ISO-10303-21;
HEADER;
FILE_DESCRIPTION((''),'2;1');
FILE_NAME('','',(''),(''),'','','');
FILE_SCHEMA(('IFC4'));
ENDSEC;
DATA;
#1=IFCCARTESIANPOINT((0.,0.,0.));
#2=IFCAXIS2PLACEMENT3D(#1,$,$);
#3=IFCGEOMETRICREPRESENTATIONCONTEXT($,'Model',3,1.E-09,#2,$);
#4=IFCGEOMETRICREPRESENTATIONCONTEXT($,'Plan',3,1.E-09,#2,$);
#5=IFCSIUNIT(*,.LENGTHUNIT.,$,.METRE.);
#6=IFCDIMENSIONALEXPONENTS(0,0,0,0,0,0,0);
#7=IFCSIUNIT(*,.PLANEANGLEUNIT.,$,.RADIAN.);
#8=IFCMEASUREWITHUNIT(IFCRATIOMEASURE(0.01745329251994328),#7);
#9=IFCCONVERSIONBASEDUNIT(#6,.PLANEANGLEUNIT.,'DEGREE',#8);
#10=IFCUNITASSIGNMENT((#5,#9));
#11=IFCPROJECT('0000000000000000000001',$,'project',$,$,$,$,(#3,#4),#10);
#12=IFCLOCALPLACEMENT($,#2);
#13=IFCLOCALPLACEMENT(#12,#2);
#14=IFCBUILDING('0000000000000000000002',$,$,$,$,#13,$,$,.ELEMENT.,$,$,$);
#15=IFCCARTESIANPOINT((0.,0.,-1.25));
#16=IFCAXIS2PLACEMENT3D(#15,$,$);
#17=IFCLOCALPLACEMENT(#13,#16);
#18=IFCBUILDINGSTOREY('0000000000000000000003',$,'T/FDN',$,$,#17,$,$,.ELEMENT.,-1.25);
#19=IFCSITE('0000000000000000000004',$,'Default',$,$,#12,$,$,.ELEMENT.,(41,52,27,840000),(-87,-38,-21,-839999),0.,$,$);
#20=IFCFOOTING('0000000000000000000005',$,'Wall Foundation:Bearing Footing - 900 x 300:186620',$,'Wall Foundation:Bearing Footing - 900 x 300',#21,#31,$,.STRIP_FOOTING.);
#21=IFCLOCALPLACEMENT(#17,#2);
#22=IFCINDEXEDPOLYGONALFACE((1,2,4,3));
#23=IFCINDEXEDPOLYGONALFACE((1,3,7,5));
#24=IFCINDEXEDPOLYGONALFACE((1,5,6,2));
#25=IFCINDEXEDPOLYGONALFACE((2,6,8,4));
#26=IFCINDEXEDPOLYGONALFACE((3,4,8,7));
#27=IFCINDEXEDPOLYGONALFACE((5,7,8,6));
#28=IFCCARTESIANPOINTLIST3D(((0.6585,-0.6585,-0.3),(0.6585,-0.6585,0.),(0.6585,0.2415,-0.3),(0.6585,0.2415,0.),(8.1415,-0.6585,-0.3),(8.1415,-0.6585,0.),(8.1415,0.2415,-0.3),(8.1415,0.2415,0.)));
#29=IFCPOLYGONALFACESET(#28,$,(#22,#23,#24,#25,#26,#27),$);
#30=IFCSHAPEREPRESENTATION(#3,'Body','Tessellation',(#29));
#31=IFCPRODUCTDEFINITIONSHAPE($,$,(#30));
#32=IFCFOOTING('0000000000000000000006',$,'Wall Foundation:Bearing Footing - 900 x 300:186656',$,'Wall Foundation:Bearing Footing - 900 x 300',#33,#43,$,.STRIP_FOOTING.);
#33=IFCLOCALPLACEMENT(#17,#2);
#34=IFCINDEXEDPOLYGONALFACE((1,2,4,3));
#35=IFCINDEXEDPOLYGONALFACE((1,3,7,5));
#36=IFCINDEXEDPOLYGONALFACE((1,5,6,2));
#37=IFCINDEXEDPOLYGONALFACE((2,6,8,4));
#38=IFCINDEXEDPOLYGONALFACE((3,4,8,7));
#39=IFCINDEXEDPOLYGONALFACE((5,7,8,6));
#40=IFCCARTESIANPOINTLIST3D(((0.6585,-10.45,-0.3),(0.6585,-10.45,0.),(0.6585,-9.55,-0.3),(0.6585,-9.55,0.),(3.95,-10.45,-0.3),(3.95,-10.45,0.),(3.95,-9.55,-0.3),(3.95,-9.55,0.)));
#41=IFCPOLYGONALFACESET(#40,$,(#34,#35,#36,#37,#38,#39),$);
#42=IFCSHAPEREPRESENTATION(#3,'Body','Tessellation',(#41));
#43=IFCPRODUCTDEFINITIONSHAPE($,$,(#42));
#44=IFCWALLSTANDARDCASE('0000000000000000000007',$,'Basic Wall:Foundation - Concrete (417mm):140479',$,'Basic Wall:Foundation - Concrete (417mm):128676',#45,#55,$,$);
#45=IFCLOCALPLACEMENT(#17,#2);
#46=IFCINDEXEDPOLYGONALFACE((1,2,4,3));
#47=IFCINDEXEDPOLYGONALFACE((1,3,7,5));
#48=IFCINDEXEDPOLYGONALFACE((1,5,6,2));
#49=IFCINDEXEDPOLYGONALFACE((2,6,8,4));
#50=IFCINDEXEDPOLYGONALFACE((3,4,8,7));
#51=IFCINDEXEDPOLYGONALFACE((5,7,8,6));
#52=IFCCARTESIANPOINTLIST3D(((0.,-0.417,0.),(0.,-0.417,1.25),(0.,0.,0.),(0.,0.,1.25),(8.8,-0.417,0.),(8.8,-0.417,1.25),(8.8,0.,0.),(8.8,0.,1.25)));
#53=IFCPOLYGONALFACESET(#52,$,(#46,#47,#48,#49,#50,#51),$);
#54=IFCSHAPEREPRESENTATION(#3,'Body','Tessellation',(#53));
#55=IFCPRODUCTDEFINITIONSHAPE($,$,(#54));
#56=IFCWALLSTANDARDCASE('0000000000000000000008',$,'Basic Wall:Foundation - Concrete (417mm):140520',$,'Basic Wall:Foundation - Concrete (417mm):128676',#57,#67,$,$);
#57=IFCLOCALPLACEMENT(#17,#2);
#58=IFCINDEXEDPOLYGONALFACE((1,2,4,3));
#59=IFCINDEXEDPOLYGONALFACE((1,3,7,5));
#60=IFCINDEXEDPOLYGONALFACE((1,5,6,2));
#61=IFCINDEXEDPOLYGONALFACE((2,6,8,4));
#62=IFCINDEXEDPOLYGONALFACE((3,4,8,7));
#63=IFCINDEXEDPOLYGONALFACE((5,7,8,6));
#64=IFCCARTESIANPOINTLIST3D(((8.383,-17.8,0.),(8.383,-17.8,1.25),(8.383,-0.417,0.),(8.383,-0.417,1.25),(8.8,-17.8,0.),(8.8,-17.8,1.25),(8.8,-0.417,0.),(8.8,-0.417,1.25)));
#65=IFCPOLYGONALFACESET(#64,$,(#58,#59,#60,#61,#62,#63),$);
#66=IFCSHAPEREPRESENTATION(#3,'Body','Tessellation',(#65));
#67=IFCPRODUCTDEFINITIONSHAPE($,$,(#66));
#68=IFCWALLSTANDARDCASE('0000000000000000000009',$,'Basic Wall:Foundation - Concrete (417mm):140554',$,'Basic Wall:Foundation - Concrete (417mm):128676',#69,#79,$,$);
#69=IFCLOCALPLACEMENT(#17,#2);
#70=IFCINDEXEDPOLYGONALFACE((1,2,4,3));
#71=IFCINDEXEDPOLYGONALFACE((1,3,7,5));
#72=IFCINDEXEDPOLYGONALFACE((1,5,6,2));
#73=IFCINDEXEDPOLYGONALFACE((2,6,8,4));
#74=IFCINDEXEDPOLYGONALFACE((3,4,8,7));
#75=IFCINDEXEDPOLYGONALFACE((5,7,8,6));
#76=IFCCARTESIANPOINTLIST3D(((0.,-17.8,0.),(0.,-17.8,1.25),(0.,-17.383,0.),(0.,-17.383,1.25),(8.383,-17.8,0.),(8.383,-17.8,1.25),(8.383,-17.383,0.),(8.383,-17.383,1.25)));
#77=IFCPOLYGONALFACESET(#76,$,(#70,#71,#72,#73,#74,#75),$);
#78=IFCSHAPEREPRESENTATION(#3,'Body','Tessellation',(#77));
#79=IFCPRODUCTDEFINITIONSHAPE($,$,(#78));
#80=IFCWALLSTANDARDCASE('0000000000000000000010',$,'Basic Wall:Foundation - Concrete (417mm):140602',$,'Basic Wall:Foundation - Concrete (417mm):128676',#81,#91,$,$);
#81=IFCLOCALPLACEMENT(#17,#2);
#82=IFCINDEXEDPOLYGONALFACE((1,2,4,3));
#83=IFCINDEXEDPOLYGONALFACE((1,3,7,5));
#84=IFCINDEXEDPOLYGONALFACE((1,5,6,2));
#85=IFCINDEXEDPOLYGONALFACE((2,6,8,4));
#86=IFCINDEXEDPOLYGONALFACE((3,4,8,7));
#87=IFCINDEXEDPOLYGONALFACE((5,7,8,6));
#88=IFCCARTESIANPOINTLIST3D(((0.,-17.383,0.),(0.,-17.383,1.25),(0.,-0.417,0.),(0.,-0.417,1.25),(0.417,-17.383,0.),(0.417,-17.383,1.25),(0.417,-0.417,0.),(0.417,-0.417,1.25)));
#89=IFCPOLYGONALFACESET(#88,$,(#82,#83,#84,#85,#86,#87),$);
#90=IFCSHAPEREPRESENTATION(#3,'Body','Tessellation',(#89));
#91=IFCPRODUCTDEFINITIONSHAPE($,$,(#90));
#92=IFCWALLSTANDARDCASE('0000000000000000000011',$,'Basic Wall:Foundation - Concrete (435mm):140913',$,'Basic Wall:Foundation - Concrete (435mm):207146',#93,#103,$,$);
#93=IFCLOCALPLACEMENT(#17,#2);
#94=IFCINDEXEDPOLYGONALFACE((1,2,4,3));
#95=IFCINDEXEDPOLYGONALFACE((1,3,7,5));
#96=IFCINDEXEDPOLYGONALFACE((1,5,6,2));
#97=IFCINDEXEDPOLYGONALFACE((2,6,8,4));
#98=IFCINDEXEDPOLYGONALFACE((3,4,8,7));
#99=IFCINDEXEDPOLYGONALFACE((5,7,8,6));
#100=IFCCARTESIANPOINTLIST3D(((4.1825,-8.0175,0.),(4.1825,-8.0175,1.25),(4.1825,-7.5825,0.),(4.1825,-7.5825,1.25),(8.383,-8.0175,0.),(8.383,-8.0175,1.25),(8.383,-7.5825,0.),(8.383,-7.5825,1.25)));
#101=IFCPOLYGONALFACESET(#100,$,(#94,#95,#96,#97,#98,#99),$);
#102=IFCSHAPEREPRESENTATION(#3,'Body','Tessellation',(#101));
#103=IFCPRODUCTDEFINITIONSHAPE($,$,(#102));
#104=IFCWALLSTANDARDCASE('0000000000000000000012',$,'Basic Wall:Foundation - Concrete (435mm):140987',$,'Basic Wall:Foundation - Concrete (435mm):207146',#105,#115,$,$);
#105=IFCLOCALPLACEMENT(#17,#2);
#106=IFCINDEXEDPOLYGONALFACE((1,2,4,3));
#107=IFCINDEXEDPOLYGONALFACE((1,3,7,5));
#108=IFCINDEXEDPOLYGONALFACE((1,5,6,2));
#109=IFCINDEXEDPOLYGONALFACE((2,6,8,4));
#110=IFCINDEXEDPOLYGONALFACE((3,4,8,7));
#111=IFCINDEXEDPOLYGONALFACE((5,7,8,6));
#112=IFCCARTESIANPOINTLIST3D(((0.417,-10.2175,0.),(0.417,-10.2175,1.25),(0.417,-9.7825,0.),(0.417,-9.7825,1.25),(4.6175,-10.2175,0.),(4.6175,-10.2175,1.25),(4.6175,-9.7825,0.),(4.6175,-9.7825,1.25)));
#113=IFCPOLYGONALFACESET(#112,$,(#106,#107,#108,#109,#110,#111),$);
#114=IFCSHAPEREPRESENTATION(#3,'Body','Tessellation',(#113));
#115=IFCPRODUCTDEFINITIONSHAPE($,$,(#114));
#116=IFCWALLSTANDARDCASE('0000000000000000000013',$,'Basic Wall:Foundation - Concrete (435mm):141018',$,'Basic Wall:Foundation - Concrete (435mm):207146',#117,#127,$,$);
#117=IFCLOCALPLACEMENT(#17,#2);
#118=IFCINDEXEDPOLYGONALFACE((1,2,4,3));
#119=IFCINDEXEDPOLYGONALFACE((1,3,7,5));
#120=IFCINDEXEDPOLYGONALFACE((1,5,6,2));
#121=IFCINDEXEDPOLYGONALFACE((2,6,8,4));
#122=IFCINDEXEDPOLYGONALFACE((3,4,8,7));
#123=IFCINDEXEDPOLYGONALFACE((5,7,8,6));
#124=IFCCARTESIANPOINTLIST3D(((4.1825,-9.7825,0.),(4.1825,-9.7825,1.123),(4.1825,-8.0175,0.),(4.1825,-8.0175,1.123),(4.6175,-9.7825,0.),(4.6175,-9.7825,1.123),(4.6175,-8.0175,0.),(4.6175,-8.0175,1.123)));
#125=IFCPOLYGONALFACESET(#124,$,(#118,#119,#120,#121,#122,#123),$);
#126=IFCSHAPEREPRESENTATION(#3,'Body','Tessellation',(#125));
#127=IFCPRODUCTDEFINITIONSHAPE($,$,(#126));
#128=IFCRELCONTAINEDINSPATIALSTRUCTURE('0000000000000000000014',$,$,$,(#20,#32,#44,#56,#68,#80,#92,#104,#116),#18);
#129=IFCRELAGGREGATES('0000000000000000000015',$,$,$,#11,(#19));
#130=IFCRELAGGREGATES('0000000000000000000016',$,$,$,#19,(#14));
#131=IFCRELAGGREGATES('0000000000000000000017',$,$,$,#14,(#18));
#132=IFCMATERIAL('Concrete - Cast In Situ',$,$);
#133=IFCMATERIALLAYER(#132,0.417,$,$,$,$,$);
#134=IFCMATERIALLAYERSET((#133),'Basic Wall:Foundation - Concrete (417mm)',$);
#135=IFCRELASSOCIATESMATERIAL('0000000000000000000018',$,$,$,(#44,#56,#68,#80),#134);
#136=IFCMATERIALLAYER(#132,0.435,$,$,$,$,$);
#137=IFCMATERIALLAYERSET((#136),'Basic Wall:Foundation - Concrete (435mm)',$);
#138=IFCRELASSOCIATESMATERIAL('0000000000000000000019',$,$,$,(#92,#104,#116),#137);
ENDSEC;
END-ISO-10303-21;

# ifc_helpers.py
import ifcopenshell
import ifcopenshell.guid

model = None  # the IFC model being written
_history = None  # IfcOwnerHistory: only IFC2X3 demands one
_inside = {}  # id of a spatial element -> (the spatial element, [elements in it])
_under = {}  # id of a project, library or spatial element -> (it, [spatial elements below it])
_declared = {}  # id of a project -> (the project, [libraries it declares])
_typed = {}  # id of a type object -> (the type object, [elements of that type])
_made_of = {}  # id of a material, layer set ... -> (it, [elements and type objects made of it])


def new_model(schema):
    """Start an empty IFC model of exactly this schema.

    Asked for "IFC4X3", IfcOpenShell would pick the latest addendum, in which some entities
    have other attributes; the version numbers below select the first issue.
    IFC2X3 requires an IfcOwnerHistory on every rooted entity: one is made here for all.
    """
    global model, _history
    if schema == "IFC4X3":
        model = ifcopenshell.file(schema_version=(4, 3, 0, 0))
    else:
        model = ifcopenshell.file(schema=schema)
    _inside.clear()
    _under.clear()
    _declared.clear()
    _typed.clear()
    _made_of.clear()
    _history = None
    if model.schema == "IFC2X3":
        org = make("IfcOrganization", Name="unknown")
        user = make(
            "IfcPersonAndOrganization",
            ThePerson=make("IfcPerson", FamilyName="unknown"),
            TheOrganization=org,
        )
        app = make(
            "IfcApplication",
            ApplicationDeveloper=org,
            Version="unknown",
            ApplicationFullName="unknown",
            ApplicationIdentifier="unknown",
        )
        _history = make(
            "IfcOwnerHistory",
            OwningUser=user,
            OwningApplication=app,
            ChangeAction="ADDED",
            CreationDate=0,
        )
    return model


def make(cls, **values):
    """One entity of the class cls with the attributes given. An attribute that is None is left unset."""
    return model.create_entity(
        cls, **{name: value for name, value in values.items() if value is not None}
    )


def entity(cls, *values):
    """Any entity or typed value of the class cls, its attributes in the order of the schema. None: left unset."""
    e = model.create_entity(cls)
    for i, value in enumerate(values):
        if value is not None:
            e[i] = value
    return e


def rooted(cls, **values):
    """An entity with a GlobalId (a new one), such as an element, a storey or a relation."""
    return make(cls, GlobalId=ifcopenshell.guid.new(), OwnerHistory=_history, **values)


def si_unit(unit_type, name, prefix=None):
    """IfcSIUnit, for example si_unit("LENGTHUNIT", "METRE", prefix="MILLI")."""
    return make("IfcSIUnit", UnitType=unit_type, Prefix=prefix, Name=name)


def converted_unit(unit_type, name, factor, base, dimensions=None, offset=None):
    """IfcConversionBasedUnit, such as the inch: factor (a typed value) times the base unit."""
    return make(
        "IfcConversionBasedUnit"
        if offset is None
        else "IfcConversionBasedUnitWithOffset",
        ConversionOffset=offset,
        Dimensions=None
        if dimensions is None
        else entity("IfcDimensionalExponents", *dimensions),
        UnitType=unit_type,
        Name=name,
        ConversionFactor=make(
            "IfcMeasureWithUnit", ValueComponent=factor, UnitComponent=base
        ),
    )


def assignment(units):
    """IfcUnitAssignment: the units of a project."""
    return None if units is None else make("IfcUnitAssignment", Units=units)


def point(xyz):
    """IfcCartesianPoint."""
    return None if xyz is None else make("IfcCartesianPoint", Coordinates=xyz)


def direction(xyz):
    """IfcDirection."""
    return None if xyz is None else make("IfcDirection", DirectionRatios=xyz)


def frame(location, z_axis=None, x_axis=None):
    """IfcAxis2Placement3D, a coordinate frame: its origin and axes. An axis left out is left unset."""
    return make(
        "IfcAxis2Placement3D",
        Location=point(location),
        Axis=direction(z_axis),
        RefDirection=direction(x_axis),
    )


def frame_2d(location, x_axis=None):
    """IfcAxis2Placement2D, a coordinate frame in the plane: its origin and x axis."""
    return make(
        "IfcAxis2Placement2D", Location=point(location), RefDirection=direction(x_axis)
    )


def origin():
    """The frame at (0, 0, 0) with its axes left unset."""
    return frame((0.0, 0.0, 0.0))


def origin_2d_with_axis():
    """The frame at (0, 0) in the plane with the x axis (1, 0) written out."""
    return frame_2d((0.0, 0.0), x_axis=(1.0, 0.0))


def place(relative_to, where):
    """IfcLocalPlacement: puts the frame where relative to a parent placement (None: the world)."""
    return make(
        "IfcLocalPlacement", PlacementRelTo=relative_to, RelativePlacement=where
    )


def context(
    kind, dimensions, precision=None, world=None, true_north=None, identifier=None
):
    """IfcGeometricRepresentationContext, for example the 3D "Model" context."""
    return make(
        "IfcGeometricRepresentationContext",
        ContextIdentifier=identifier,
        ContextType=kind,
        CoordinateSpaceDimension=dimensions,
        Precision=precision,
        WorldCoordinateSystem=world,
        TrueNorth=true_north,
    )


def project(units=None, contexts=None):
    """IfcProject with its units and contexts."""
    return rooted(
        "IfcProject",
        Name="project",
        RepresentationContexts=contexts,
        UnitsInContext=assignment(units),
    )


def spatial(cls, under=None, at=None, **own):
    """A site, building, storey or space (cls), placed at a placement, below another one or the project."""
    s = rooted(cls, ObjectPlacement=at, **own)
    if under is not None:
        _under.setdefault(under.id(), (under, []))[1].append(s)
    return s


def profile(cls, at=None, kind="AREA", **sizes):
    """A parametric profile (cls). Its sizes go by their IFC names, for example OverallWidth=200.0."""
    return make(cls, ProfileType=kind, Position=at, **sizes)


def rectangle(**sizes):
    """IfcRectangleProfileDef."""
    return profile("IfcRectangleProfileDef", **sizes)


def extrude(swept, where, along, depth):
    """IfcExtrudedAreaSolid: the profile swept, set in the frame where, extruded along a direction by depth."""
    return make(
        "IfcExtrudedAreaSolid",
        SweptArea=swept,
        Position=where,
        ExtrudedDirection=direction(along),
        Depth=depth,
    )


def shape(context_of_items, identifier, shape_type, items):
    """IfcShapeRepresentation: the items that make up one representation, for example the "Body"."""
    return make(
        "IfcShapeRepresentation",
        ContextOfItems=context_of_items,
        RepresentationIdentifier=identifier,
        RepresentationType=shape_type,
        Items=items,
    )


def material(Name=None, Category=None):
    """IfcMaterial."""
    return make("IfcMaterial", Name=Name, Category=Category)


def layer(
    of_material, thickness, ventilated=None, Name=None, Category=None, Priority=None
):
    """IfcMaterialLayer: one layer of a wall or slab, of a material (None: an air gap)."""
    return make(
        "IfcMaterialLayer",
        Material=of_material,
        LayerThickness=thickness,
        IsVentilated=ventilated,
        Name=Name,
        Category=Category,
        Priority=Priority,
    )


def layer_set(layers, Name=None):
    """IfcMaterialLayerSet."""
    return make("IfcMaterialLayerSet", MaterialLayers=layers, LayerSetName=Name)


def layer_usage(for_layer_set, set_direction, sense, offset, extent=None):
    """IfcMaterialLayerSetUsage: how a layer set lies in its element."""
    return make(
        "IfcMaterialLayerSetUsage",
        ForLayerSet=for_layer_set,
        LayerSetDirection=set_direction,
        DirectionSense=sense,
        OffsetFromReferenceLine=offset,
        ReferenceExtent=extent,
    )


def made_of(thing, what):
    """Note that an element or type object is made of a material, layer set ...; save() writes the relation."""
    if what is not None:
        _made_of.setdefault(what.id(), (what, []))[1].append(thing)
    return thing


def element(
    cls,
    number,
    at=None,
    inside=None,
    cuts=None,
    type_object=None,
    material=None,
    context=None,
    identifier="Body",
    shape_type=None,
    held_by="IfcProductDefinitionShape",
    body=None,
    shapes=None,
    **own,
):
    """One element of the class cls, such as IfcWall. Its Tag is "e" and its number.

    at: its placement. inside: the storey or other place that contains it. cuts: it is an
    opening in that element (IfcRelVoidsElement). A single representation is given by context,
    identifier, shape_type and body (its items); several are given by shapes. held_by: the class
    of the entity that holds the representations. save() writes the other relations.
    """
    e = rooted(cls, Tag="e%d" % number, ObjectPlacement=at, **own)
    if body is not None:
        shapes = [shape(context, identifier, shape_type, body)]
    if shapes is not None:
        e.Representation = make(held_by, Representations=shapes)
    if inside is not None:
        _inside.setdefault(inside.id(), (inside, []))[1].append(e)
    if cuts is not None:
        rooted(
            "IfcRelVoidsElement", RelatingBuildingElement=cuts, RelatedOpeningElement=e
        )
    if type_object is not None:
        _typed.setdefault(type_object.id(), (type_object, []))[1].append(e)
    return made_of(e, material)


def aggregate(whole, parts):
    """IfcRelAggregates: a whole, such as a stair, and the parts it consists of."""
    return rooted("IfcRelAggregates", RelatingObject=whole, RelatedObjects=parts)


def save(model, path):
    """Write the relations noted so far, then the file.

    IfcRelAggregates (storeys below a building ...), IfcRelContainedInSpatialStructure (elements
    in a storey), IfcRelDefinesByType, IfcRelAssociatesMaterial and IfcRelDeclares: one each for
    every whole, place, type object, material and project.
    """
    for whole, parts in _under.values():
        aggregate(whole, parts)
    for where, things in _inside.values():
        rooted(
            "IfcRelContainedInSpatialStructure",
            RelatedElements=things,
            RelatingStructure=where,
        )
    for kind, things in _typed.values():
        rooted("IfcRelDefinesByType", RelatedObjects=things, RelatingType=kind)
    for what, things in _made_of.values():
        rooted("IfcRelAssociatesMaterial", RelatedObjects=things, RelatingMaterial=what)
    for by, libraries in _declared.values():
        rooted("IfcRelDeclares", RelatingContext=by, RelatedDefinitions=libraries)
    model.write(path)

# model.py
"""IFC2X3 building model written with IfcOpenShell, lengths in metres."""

from ifc_helpers import new_model, entity, si_unit, converted_unit, frame, frame_2d, origin, origin_2d_with_axis, place, context, project, spatial, rectangle, extrude, material, layer, layer_set, layer_usage, element, save


model = new_model("IFC2X3")

# Units and contexts
model_context = context("Model", 3, precision=1e-09, world=origin())
plan_context = context("Plan", 3, precision=1e-09, world=origin())
ifc_project = project(units=[si_unit("LENGTHUNIT", "METRE"), converted_unit("PLANEANGLEUNIT", "DEGREE", entity("IfcRatioMeasure", 0.01745329251994328), si_unit("PLANEANGLEUNIT", "RADIAN"), dimensions=[0, 0, 0, 0, 0, 0, 0])], contexts=[model_context, plan_context])

# Site, building, storey
site_placement = place(None, origin())
site = spatial("IfcSite", under=ifc_project, at=site_placement, Name="Default", CompositionType="ELEMENT", RefLatitude=(41, 52, 27, 840000), RefLongitude=(-87, -38, -21, -839999), RefElevation=0.0)
building_placement = place(site_placement, origin())
building = spatial("IfcBuilding", under=site, at=building_placement, CompositionType="ELEMENT")
storey_placement = place(building_placement, frame((0.0, 0.0, -1.25)))
storey = spatial("IfcBuildingStorey", under=building, at=storey_placement, Name="T/FDN", CompositionType="ELEMENT", Elevation=-1.25)

# Footings
footing_1_placement = place(storey_placement, origin())
element("IfcFooting", 1, at=footing_1_placement, inside=storey, Name="Wall Foundation:Bearing Footing - 900 x 300:186620", ObjectType="Wall Foundation:Bearing Footing - 900 x 300", PredefinedType="STRIP_FOOTING", context=model_context, shape_type="SweptSolid", body=[
    extrude(rectangle(XDim=7.483, YDim=0.9, at=origin_2d_with_axis()), frame((4.4, -0.2085, -0.3), z_axis=(0.0, 0.0, 1.0), x_axis=(-1.0, 0.0, 0.0)), (0.0, 0.0, 1.0), 0.3),
])
footing_2_placement = place(storey_placement, origin())
element("IfcFooting", 2, at=footing_2_placement, inside=storey, Name="Wall Foundation:Bearing Footing - 900 x 300:186656", ObjectType="Wall Foundation:Bearing Footing - 900 x 300", PredefinedType="STRIP_FOOTING", context=model_context, shape_type="SweptSolid", body=[
    extrude(rectangle(XDim=3.2915, YDim=0.9, at=origin_2d_with_axis()), frame((2.3042, -10.0, -0.3)), (0.0, 0.0, 1.0), 0.3),
])

# Walls
ifc_material = material(Name="Concrete - Cast In Situ")
ifc_layer_1 = layer(ifc_material, 0.417)
ifc_layer_set_1 = layer_set([ifc_layer_1], Name="Basic Wall:Foundation - Concrete (417mm)")
ifc_layer_usage_1 = layer_usage(ifc_layer_set_1, "AXIS2", "NEGATIVE", 0.2085)
wall_1_placement = place(storey_placement, frame((0.0, -0.2085, 0.0)))
element("IfcWallStandardCase", 3, at=wall_1_placement, inside=storey, material=ifc_layer_usage_1, Name="Basic Wall:Foundation - Concrete (417mm):140479", ObjectType="Basic Wall:Foundation - Concrete (417mm):128676", context=model_context, shape_type="SweptSolid", body=[
    extrude(rectangle(XDim=8.8, YDim=0.417, at=frame_2d((4.4, 0.0), x_axis=(-1.0, 0.0))), origin(), (0.0, 0.0, 1.0), 1.25),
])
ifc_layer_usage_2 = layer_usage(ifc_layer_set_1, "AXIS2", "NEGATIVE", 0.2085)
wall_2_placement = place(storey_placement, frame((8.5915, -0.417, 0.0), z_axis=(0.0, 0.0, 1.0), x_axis=(0.0, -1.0, 0.0)))
element("IfcWallStandardCase", 4, at=wall_2_placement, inside=storey, material=ifc_layer_usage_2, Name="Basic Wall:Foundation - Concrete (417mm):140520", ObjectType="Basic Wall:Foundation - Concrete (417mm):128676", context=model_context, shape_type="SweptSolid", body=[
    extrude(rectangle(XDim=17.383, YDim=0.417, at=frame_2d((8.6915, 0.0), x_axis=(-1.0, 0.0))), origin(), (0.0, 0.0, 1.0), 1.25),
])
ifc_layer_usage_3 = layer_usage(ifc_layer_set_1, "AXIS2", "NEGATIVE", 0.2085)
wall_3_placement = place(storey_placement, frame((8.383, -17.5915, 0.0), z_axis=(0.0, 0.0, 1.0), x_axis=(-1.0, 0.0, 0.0)))
element("IfcWallStandardCase", 5, at=wall_3_placement, inside=storey, material=ifc_layer_usage_3, Name="Basic Wall:Foundation - Concrete (417mm):140554", ObjectType="Basic Wall:Foundation - Concrete (417mm):128676", context=model_context, shape_type="SweptSolid", body=[
    extrude(rectangle(XDim=8.383, YDim=0.417, at=frame_2d((4.1915, 0.0), x_axis=(-1.0, 0.0))), origin(), (0.0, 0.0, 1.0), 1.25),
])
ifc_layer_usage_4 = layer_usage(ifc_layer_set_1, "AXIS2", "NEGATIVE", 0.2085)
wall_4_placement = place(storey_placement, frame((0.2085, -17.383, 0.0), z_axis=(0.0, 0.0, 1.0), x_axis=(0.0, 1.0, 0.0)))
element("IfcWallStandardCase", 6, at=wall_4_placement, inside=storey, material=ifc_layer_usage_4, Name="Basic Wall:Foundation - Concrete (417mm):140602", ObjectType="Basic Wall:Foundation - Concrete (417mm):128676", context=model_context, shape_type="SweptSolid", body=[
    extrude(rectangle(XDim=16.966, YDim=0.417, at=frame_2d((8.483, 0.0), x_axis=(-1.0, 0.0))), origin(), (0.0, 0.0, 1.0), 1.25),
])
ifc_layer_2 = layer(ifc_material, 0.435)
ifc_layer_set_2 = layer_set([ifc_layer_2], Name="Basic Wall:Foundation - Concrete (435mm)")
ifc_layer_usage_5 = layer_usage(ifc_layer_set_2, "AXIS2", "NEGATIVE", 0.2175)
wall_5_placement = place(storey_placement, frame((8.383, -7.8, 0.0), z_axis=(0.0, 0.0, 1.0), x_axis=(-1.0, 0.0, 0.0)))
element("IfcWallStandardCase", 7, at=wall_5_placement, inside=storey, material=ifc_layer_usage_5, Name="Basic Wall:Foundation - Concrete (435mm):140913", ObjectType="Basic Wall:Foundation - Concrete (435mm):207146", context=model_context, shape_type="SweptSolid", body=[
    extrude(rectangle(XDim=4.2005, YDim=0.435, at=frame_2d((2.1002, 0.0), x_axis=(-1.0, 0.0))), origin(), (0.0, 0.0, 1.0), 1.25),
])
ifc_layer_usage_6 = layer_usage(ifc_layer_set_2, "AXIS2", "NEGATIVE", 0.2175)
wall_6_placement = place(storey_placement, frame((0.417, -10.0, 0.0)))
element("IfcWallStandardCase", 8, at=wall_6_placement, inside=storey, material=ifc_layer_usage_6, Name="Basic Wall:Foundation - Concrete (435mm):140987", ObjectType="Basic Wall:Foundation - Concrete (435mm):207146", context=model_context, shape_type="SweptSolid", body=[
    extrude(rectangle(XDim=4.2005, YDim=0.435, at=frame_2d((2.1002, 0.0), x_axis=(-1.0, 0.0))), origin(), (0.0, 0.0, 1.0), 1.25),
])
ifc_layer_usage_7 = layer_usage(ifc_layer_set_2, "AXIS2", "NEGATIVE", 0.2175)
wall_7_placement = place(storey_placement, frame((4.4, -9.7825, 0.0), z_axis=(0.0, 0.0, 1.0), x_axis=(0.0, 1.0, 0.0)))
element("IfcWallStandardCase", 9, at=wall_7_placement, inside=storey, material=ifc_layer_usage_7, Name="Basic Wall:Foundation - Concrete (435mm):141018", ObjectType="Basic Wall:Foundation - Concrete (435mm):207146", context=model_context, shape_type="SweptSolid", body=[
    extrude(rectangle(XDim=1.765, YDim=0.435, at=frame_2d((0.8825, 0.0), x_axis=(-1.0, 0.0))), origin(), (0.0, 0.0, 1.0), 1.123),
])

save(model, "model.ifc")
